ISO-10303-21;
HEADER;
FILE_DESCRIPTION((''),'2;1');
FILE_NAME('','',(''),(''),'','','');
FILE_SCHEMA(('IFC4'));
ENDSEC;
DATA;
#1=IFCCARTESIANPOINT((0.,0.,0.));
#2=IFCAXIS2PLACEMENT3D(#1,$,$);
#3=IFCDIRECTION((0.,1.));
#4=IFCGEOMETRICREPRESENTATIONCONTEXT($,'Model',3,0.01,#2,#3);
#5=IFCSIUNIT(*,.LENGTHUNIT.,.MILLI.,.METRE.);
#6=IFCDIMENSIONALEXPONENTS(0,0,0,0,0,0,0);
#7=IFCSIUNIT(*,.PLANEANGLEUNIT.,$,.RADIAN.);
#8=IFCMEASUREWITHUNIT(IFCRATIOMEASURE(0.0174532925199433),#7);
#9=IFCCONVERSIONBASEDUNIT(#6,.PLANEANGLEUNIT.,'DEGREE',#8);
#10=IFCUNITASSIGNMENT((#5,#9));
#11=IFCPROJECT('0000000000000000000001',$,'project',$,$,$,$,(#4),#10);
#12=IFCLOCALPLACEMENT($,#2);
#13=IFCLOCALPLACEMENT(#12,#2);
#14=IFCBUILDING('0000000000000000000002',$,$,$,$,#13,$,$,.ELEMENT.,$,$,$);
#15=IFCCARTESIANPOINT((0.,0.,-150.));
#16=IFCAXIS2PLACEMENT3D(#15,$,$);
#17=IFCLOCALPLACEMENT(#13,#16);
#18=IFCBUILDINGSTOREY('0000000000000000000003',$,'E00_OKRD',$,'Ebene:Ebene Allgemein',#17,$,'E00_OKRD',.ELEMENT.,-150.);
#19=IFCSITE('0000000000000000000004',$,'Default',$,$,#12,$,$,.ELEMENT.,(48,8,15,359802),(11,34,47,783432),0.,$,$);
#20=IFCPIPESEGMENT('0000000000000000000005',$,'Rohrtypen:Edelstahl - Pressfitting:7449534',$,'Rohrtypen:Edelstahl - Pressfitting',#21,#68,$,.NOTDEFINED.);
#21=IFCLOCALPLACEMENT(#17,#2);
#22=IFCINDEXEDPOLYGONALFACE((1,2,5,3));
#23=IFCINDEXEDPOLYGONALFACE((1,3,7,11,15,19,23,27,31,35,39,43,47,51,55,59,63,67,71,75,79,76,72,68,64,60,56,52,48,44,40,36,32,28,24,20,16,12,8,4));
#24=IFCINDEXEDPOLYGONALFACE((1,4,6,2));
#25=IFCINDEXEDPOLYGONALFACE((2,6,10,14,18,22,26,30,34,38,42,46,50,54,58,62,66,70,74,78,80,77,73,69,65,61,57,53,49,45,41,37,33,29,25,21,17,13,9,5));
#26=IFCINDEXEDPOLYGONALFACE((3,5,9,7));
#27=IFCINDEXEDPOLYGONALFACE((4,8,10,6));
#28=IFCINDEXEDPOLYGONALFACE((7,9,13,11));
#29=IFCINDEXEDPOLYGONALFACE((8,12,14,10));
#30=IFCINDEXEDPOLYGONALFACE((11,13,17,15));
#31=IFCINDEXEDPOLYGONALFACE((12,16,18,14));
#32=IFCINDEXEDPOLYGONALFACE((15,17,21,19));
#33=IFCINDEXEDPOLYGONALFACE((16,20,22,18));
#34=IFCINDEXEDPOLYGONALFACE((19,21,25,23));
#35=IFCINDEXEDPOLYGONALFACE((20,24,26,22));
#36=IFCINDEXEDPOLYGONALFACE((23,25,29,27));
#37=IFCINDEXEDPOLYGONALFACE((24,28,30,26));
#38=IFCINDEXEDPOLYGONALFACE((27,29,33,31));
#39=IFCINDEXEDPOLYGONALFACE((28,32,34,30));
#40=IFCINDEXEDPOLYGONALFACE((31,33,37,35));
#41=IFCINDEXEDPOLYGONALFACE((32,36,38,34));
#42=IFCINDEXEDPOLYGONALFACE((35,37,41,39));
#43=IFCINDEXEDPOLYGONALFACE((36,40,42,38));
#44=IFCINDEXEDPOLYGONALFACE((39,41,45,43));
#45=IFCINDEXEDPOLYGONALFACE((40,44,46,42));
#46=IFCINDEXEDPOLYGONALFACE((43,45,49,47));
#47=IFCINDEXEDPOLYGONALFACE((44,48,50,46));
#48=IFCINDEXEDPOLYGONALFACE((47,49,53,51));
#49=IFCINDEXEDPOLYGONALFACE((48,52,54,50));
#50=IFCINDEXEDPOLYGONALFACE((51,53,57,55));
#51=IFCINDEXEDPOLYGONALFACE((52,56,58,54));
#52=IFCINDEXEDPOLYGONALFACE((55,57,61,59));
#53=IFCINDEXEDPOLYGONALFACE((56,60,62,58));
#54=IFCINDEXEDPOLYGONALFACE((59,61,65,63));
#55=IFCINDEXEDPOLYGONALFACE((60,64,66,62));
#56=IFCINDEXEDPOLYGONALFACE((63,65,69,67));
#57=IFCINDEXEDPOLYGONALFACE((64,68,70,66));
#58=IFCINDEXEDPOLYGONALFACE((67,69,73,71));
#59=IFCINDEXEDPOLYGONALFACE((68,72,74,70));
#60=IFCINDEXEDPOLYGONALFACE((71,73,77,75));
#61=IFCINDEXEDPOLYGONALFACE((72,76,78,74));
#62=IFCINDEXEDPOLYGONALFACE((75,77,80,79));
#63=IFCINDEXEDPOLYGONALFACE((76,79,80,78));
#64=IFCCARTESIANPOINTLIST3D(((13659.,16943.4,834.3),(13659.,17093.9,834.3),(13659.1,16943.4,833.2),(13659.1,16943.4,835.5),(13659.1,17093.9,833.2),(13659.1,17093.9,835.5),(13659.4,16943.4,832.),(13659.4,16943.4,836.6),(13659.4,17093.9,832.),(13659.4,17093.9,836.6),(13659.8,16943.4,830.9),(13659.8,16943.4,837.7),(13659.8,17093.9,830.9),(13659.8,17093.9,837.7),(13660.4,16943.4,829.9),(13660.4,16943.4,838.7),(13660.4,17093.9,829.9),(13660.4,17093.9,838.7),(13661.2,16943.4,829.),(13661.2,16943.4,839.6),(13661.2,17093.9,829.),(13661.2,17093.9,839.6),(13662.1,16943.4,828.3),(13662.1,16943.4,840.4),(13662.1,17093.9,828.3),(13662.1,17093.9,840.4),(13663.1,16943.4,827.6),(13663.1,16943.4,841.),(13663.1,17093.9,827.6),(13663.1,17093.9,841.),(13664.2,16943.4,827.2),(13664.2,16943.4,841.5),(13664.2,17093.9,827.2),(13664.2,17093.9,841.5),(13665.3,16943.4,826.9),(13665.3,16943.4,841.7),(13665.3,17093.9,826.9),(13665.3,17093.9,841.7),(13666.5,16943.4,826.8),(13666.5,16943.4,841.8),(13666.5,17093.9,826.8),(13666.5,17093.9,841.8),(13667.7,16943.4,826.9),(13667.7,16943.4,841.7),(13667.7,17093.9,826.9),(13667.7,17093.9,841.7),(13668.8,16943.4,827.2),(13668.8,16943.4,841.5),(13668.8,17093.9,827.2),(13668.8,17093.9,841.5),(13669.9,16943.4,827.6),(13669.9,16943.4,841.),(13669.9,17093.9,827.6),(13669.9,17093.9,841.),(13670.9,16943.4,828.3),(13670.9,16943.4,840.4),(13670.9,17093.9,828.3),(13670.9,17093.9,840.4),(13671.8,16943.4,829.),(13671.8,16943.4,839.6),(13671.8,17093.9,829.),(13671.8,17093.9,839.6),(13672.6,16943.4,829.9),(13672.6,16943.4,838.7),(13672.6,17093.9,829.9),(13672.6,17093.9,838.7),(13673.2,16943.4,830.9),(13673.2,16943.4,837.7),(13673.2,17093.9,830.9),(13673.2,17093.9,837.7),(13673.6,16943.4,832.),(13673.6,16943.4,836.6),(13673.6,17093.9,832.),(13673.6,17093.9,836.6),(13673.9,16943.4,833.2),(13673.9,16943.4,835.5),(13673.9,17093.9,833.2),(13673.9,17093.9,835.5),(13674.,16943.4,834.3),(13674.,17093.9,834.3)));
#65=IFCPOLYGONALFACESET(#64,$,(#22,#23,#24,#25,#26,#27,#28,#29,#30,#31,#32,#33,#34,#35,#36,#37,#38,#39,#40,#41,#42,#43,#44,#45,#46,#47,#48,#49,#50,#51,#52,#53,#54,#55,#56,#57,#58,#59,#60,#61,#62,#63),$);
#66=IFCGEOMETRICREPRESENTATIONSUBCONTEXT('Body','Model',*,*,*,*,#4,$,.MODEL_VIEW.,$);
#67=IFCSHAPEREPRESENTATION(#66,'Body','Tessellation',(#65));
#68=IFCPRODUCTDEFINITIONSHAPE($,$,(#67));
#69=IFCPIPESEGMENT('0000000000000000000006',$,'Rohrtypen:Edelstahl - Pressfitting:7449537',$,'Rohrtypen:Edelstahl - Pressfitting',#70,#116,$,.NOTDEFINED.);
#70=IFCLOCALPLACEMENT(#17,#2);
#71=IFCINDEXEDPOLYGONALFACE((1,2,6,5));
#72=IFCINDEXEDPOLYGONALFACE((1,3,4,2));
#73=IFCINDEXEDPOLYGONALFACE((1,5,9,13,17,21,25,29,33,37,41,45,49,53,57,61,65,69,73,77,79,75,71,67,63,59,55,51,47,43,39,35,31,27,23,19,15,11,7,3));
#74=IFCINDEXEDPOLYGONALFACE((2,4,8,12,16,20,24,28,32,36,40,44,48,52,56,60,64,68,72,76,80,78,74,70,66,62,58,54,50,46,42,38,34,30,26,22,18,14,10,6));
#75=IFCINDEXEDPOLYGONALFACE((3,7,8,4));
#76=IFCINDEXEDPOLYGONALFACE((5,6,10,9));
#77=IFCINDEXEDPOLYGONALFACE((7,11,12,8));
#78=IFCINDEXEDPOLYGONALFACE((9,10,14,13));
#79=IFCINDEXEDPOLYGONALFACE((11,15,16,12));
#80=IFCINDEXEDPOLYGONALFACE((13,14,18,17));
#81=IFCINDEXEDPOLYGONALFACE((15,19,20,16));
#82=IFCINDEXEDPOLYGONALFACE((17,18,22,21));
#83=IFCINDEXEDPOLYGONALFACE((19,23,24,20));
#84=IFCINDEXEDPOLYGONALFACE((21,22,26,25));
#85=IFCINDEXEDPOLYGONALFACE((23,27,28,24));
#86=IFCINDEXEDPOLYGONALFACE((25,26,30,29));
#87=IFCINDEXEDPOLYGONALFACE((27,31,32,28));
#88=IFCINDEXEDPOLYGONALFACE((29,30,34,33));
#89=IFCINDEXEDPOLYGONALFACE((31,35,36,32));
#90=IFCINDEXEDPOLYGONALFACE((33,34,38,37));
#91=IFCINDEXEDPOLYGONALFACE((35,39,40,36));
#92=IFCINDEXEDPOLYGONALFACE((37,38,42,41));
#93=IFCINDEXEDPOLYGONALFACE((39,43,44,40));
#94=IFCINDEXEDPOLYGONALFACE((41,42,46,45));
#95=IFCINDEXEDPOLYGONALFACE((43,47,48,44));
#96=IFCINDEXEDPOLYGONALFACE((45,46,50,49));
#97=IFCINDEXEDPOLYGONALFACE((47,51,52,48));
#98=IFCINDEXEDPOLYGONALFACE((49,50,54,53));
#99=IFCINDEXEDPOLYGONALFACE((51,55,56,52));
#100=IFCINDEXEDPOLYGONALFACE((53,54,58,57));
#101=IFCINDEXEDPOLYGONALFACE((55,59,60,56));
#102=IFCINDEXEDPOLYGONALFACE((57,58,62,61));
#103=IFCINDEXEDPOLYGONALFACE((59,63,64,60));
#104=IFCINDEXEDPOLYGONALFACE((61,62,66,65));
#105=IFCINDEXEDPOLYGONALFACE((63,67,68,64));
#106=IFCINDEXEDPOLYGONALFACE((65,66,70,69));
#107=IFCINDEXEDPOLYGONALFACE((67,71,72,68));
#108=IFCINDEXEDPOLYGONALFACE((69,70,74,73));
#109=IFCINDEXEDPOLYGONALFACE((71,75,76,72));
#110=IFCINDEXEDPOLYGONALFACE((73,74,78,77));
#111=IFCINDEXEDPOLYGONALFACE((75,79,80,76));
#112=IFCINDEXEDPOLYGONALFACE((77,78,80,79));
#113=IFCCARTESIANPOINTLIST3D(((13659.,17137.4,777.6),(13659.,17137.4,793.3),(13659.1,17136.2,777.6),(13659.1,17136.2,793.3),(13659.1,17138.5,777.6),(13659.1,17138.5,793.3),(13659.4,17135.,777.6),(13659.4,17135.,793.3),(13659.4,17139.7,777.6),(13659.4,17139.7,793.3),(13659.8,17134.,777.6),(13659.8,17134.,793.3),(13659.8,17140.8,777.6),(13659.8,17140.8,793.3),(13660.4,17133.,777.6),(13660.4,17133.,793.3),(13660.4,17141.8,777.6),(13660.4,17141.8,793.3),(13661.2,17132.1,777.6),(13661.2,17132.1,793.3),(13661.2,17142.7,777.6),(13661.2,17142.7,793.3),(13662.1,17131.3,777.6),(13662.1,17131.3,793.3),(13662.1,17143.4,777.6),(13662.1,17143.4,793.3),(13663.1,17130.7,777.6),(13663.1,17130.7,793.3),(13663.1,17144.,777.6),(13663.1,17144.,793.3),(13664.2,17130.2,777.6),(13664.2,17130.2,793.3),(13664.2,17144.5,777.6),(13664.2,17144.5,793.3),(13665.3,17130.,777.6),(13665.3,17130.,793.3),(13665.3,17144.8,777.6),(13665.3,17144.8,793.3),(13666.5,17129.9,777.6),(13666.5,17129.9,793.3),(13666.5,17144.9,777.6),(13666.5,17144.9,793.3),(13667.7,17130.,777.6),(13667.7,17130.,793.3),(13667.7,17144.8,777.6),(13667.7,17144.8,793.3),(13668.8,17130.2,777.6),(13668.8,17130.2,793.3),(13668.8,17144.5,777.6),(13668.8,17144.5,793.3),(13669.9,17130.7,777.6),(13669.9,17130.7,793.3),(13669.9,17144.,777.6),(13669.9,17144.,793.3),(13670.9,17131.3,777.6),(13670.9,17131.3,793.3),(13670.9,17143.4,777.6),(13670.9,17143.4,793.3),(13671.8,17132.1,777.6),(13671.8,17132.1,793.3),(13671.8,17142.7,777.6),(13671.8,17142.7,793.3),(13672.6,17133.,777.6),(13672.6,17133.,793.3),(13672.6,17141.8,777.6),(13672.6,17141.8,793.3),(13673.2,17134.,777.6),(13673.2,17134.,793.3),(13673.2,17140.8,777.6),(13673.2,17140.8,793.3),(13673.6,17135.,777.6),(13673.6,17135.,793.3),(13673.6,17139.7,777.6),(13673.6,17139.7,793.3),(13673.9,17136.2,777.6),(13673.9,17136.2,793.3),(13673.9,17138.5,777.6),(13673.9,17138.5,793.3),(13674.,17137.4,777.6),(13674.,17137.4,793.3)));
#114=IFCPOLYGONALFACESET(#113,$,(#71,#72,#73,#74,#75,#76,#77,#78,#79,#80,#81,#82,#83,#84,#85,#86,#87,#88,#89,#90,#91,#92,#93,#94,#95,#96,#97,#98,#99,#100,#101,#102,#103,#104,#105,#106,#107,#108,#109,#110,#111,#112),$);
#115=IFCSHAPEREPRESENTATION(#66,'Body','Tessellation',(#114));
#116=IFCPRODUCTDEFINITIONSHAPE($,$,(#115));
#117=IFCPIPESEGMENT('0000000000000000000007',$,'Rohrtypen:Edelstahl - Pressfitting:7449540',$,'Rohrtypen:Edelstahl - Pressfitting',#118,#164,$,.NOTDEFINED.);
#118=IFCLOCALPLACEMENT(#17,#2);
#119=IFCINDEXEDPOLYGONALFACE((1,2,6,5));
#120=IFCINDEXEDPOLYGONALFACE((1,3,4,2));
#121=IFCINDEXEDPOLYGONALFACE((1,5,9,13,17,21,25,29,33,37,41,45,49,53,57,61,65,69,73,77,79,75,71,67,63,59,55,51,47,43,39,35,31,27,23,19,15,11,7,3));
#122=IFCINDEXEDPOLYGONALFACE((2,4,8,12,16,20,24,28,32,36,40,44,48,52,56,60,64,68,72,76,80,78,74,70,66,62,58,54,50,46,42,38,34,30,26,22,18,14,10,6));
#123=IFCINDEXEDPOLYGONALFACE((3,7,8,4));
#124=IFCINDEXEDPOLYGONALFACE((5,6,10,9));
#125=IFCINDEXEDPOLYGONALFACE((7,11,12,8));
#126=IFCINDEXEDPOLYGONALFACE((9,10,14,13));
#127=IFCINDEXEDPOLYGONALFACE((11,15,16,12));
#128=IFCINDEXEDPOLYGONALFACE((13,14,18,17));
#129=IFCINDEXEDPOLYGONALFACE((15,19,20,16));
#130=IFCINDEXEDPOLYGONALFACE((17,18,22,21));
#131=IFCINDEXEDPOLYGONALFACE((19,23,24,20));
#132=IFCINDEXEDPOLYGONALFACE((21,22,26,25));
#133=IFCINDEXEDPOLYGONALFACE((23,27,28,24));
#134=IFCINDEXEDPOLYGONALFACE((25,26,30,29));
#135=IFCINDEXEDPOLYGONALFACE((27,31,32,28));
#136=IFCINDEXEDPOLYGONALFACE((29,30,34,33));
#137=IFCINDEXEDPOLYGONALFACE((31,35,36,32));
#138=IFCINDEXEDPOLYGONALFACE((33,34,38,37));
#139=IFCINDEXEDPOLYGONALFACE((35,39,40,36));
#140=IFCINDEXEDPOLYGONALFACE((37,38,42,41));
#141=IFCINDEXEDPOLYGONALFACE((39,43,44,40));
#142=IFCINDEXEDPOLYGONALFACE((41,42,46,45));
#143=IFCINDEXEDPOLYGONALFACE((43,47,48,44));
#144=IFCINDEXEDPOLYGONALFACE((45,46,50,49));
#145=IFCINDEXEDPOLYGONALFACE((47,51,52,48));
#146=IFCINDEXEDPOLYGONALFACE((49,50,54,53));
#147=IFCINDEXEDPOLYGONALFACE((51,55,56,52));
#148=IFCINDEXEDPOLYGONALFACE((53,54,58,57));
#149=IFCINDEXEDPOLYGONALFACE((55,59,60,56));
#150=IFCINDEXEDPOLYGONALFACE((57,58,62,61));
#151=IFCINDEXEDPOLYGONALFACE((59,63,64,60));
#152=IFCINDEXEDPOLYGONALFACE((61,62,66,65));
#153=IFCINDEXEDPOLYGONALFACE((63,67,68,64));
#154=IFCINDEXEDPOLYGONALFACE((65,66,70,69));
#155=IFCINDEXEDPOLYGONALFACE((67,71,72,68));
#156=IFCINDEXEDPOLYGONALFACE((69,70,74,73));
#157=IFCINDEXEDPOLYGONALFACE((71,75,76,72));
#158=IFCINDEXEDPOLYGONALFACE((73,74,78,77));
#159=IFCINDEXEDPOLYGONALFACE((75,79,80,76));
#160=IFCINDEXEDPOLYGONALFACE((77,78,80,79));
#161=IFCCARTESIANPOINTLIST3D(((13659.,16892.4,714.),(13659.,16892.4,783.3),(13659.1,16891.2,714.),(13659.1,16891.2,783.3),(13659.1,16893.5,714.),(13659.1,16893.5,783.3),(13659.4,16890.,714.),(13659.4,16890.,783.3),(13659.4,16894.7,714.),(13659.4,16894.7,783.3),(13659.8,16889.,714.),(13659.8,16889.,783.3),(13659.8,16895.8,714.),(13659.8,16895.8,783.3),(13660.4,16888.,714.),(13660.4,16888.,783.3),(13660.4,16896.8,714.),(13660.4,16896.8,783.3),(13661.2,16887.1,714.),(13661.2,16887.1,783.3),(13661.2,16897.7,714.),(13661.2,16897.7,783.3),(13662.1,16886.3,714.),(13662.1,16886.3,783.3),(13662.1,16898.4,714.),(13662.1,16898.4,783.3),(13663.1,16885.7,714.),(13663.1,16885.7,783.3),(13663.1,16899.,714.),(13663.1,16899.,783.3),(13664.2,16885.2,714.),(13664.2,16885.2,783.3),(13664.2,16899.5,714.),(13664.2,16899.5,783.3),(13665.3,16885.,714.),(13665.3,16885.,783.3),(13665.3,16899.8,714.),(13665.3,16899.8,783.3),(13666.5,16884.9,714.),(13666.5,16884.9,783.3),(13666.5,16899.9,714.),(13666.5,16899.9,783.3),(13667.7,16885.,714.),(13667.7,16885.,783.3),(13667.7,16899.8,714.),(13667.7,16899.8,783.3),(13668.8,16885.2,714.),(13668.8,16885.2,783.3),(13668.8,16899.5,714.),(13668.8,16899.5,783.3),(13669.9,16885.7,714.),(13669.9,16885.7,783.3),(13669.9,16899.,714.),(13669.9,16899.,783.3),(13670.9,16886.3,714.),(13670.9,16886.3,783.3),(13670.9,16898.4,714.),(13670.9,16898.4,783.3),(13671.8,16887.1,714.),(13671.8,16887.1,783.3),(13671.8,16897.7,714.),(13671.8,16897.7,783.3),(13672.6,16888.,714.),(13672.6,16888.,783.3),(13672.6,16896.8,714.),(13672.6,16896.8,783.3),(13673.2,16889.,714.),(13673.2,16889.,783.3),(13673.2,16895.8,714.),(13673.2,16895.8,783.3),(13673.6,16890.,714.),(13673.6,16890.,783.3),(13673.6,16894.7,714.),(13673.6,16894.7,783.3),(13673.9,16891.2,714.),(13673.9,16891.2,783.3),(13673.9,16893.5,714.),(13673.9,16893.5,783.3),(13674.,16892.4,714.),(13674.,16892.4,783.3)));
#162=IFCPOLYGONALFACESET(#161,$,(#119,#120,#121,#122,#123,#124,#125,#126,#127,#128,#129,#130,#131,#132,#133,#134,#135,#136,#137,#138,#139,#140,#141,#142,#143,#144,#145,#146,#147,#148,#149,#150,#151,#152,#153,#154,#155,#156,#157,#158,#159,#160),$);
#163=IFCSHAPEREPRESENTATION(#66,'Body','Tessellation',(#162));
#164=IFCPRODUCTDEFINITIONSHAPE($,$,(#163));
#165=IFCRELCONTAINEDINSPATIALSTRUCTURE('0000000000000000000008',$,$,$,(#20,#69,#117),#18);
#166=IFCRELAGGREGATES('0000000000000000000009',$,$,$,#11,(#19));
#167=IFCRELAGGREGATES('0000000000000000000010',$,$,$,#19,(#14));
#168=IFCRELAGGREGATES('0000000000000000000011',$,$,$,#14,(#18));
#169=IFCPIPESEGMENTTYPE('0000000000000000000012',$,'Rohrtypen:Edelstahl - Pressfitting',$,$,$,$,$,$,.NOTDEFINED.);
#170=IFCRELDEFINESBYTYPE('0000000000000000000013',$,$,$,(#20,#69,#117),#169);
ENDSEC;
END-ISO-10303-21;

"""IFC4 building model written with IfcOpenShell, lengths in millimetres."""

from ifc_helpers import new_model, entity, si_unit, converted_unit, direction, frame, origin, place, context, subcontext, project, spatial, indexed_curve, outline, extrude, type_object, element, save


model = new_model("IFC4")

# Units and contexts
model_context = context("Model", 3, precision=0.01, world=origin(), true_north=direction((0.0, 1.0)))
body_context = subcontext(model_context, "Body", "Model", "MODEL_VIEW")
ifc_project = project(units=[si_unit("LENGTHUNIT", "METRE", prefix="MILLI"), converted_unit("PLANEANGLEUNIT", "DEGREE", entity("IfcRatioMeasure", 0.0174532925199433), si_unit("PLANEANGLEUNIT", "RADIAN"), dimensions=[0, 0, 0, 0, 0, 0, 0])], contexts=[model_context])

# Site, building, storey
site_placement = place(None, origin())
site = spatial("IfcSite", under=ifc_project, at=site_placement, Name="Default", CompositionType="ELEMENT", RefLatitude=(48, 8, 15, 359802), RefLongitude=(11, 34, 47, 783432), RefElevation=0.0)
building_placement = place(site_placement, origin())
building = spatial("IfcBuilding", under=site, at=building_placement, CompositionType="ELEMENT")
storey_placement = place(building_placement, frame((0.0, 0.0, -150.0)))
storey = spatial("IfcBuildingStorey", under=building, at=storey_placement, Name="E00_OKRD", ObjectType="Ebene:Ebene Allgemein", LongName="E00_OKRD", CompositionType="ELEMENT", Elevation=-150.0)

# Pipe segments
pipe_segment_type_1 = type_object("IfcPipeSegmentType", Name="Rohrtypen:Edelstahl - Pressfitting", PredefinedType="NOTDEFINED")
pipe_segment_1_placement = place(storey_placement, origin())
element("IfcPipeSegment", 1, at=pipe_segment_1_placement, inside=storey, type_object=pipe_segment_type_1, Name="Rohrtypen:Edelstahl - Pressfitting:7449534", ObjectType="Rohrtypen:Edelstahl - Pressfitting", PredefinedType="NOTDEFINED", context=body_context, shape_type="SweptSolid", body=[
    extrude(outline(indexed_curve([(7.5, 0.0), (7.4, 1.2), (7.1, 2.3), (6.7, 3.4), (6.1, 4.4), (5.3, 5.3), (4.4, 6.1), (3.4, 6.7), (2.3, 7.1), (1.2, 7.4), (0.0, 7.5), (-1.2, 7.4), (-2.3, 7.1), (-3.4, 6.7), (-4.4, 6.1), (-5.3, 5.3), (-6.1, 4.4), (-6.7, 3.4), (-7.1, 2.3), (-7.4, 1.2), (-7.5, 0.0), (-7.4, -1.2), (-7.1, -2.3), (-6.7, -3.4), (-6.1, -4.4), (-5.3, -5.3), (-4.4, -6.1), (-3.4, -6.7), (-2.3, -7.1), (-1.2, -7.4), (0.0, -7.5), (1.2, -7.4), (2.3, -7.1), (3.4, -6.7), (4.4, -6.1), (5.3, -5.3), (6.1, -4.4), (6.7, -3.4), (7.1, -2.3), (7.4, -1.2), (7.5, 0.0)], self_intersect=False)), frame((13666.5, 16943.4, 834.3), z_axis=(0.000017, 1.0, 0.0), x_axis=(-1.0, 0.000017, 0.0)), (0.0, 0.0, 1.0), 150.5),
])
pipe_segment_2_placement = place(storey_placement, origin())
element("IfcPipeSegment", 2, at=pipe_segment_2_placement, inside=storey, type_object=pipe_segment_type_1, Name="Rohrtypen:Edelstahl - Pressfitting:7449537", ObjectType="Rohrtypen:Edelstahl - Pressfitting", PredefinedType="NOTDEFINED", context=body_context, shape_type="SweptSolid", body=[
    extrude(outline(indexed_curve([(7.5, 0.0), (7.4, 1.2), (7.1, 2.3), (6.7, 3.4), (6.1, 4.4), (5.3, 5.3), (4.4, 6.1), (3.4, 6.7), (2.3, 7.1), (1.2, 7.4), (0.0, 7.5), (-1.2, 7.4), (-2.3, 7.1), (-3.4, 6.7), (-4.4, 6.1), (-5.3, 5.3), (-6.1, 4.4), (-6.7, 3.4), (-7.1, 2.3), (-7.4, 1.2), (-7.5, 0.0), (-7.4, -1.2), (-7.1, -2.3), (-6.7, -3.4), (-6.1, -4.4), (-5.3, -5.3), (-4.4, -6.1), (-3.4, -6.7), (-2.3, -7.1), (-1.2, -7.4), (0.0, -7.5), (1.2, -7.4), (2.3, -7.1), (3.4, -6.7), (4.4, -6.1), (5.3, -5.3), (6.1, -4.4), (6.7, -3.4), (7.1, -2.3), (7.4, -1.2), (7.5, 0.0)], self_intersect=False)), frame((13666.5, 17137.4, 777.6), z_axis=(0.0, 0.0, 1.0), x_axis=(-1.0, 0.0, 0.0)), (0.0, 0.0, 1.0), 15.7),
])
pipe_segment_3_placement = place(storey_placement, origin())
element("IfcPipeSegment", 3, at=pipe_segment_3_placement, inside=storey, type_object=pipe_segment_type_1, Name="Rohrtypen:Edelstahl - Pressfitting:7449540", ObjectType="Rohrtypen:Edelstahl - Pressfitting", PredefinedType="NOTDEFINED", context=body_context, shape_type="SweptSolid", body=[
    extrude(outline(indexed_curve([(7.5, 0.0), (7.4, 1.2), (7.1, 2.3), (6.7, 3.4), (6.1, 4.4), (5.3, 5.3), (4.4, 6.1), (3.4, 6.7), (2.3, 7.1), (1.2, 7.4), (0.0, 7.5), (-1.2, 7.4), (-2.3, 7.1), (-3.4, 6.7), (-4.4, 6.1), (-5.3, 5.3), (-6.1, 4.4), (-6.7, 3.4), (-7.1, 2.3), (-7.4, 1.2), (-7.5, 0.0), (-7.4, -1.2), (-7.1, -2.3), (-6.7, -3.4), (-6.1, -4.4), (-5.3, -5.3), (-4.4, -6.1), (-3.4, -6.7), (-2.3, -7.1), (-1.2, -7.4), (0.0, -7.5), (1.2, -7.4), (2.3, -7.1), (3.4, -6.7), (4.4, -6.1), (5.3, -5.3), (6.1, -4.4), (6.7, -3.4), (7.1, -2.3), (7.4, -1.2), (7.5, 0.0)], self_intersect=False)), frame((13666.5, 16892.4, 714.0)), (0.0, 0.0, 1.0), 69.3),
])

save(model, "model.ifc")
